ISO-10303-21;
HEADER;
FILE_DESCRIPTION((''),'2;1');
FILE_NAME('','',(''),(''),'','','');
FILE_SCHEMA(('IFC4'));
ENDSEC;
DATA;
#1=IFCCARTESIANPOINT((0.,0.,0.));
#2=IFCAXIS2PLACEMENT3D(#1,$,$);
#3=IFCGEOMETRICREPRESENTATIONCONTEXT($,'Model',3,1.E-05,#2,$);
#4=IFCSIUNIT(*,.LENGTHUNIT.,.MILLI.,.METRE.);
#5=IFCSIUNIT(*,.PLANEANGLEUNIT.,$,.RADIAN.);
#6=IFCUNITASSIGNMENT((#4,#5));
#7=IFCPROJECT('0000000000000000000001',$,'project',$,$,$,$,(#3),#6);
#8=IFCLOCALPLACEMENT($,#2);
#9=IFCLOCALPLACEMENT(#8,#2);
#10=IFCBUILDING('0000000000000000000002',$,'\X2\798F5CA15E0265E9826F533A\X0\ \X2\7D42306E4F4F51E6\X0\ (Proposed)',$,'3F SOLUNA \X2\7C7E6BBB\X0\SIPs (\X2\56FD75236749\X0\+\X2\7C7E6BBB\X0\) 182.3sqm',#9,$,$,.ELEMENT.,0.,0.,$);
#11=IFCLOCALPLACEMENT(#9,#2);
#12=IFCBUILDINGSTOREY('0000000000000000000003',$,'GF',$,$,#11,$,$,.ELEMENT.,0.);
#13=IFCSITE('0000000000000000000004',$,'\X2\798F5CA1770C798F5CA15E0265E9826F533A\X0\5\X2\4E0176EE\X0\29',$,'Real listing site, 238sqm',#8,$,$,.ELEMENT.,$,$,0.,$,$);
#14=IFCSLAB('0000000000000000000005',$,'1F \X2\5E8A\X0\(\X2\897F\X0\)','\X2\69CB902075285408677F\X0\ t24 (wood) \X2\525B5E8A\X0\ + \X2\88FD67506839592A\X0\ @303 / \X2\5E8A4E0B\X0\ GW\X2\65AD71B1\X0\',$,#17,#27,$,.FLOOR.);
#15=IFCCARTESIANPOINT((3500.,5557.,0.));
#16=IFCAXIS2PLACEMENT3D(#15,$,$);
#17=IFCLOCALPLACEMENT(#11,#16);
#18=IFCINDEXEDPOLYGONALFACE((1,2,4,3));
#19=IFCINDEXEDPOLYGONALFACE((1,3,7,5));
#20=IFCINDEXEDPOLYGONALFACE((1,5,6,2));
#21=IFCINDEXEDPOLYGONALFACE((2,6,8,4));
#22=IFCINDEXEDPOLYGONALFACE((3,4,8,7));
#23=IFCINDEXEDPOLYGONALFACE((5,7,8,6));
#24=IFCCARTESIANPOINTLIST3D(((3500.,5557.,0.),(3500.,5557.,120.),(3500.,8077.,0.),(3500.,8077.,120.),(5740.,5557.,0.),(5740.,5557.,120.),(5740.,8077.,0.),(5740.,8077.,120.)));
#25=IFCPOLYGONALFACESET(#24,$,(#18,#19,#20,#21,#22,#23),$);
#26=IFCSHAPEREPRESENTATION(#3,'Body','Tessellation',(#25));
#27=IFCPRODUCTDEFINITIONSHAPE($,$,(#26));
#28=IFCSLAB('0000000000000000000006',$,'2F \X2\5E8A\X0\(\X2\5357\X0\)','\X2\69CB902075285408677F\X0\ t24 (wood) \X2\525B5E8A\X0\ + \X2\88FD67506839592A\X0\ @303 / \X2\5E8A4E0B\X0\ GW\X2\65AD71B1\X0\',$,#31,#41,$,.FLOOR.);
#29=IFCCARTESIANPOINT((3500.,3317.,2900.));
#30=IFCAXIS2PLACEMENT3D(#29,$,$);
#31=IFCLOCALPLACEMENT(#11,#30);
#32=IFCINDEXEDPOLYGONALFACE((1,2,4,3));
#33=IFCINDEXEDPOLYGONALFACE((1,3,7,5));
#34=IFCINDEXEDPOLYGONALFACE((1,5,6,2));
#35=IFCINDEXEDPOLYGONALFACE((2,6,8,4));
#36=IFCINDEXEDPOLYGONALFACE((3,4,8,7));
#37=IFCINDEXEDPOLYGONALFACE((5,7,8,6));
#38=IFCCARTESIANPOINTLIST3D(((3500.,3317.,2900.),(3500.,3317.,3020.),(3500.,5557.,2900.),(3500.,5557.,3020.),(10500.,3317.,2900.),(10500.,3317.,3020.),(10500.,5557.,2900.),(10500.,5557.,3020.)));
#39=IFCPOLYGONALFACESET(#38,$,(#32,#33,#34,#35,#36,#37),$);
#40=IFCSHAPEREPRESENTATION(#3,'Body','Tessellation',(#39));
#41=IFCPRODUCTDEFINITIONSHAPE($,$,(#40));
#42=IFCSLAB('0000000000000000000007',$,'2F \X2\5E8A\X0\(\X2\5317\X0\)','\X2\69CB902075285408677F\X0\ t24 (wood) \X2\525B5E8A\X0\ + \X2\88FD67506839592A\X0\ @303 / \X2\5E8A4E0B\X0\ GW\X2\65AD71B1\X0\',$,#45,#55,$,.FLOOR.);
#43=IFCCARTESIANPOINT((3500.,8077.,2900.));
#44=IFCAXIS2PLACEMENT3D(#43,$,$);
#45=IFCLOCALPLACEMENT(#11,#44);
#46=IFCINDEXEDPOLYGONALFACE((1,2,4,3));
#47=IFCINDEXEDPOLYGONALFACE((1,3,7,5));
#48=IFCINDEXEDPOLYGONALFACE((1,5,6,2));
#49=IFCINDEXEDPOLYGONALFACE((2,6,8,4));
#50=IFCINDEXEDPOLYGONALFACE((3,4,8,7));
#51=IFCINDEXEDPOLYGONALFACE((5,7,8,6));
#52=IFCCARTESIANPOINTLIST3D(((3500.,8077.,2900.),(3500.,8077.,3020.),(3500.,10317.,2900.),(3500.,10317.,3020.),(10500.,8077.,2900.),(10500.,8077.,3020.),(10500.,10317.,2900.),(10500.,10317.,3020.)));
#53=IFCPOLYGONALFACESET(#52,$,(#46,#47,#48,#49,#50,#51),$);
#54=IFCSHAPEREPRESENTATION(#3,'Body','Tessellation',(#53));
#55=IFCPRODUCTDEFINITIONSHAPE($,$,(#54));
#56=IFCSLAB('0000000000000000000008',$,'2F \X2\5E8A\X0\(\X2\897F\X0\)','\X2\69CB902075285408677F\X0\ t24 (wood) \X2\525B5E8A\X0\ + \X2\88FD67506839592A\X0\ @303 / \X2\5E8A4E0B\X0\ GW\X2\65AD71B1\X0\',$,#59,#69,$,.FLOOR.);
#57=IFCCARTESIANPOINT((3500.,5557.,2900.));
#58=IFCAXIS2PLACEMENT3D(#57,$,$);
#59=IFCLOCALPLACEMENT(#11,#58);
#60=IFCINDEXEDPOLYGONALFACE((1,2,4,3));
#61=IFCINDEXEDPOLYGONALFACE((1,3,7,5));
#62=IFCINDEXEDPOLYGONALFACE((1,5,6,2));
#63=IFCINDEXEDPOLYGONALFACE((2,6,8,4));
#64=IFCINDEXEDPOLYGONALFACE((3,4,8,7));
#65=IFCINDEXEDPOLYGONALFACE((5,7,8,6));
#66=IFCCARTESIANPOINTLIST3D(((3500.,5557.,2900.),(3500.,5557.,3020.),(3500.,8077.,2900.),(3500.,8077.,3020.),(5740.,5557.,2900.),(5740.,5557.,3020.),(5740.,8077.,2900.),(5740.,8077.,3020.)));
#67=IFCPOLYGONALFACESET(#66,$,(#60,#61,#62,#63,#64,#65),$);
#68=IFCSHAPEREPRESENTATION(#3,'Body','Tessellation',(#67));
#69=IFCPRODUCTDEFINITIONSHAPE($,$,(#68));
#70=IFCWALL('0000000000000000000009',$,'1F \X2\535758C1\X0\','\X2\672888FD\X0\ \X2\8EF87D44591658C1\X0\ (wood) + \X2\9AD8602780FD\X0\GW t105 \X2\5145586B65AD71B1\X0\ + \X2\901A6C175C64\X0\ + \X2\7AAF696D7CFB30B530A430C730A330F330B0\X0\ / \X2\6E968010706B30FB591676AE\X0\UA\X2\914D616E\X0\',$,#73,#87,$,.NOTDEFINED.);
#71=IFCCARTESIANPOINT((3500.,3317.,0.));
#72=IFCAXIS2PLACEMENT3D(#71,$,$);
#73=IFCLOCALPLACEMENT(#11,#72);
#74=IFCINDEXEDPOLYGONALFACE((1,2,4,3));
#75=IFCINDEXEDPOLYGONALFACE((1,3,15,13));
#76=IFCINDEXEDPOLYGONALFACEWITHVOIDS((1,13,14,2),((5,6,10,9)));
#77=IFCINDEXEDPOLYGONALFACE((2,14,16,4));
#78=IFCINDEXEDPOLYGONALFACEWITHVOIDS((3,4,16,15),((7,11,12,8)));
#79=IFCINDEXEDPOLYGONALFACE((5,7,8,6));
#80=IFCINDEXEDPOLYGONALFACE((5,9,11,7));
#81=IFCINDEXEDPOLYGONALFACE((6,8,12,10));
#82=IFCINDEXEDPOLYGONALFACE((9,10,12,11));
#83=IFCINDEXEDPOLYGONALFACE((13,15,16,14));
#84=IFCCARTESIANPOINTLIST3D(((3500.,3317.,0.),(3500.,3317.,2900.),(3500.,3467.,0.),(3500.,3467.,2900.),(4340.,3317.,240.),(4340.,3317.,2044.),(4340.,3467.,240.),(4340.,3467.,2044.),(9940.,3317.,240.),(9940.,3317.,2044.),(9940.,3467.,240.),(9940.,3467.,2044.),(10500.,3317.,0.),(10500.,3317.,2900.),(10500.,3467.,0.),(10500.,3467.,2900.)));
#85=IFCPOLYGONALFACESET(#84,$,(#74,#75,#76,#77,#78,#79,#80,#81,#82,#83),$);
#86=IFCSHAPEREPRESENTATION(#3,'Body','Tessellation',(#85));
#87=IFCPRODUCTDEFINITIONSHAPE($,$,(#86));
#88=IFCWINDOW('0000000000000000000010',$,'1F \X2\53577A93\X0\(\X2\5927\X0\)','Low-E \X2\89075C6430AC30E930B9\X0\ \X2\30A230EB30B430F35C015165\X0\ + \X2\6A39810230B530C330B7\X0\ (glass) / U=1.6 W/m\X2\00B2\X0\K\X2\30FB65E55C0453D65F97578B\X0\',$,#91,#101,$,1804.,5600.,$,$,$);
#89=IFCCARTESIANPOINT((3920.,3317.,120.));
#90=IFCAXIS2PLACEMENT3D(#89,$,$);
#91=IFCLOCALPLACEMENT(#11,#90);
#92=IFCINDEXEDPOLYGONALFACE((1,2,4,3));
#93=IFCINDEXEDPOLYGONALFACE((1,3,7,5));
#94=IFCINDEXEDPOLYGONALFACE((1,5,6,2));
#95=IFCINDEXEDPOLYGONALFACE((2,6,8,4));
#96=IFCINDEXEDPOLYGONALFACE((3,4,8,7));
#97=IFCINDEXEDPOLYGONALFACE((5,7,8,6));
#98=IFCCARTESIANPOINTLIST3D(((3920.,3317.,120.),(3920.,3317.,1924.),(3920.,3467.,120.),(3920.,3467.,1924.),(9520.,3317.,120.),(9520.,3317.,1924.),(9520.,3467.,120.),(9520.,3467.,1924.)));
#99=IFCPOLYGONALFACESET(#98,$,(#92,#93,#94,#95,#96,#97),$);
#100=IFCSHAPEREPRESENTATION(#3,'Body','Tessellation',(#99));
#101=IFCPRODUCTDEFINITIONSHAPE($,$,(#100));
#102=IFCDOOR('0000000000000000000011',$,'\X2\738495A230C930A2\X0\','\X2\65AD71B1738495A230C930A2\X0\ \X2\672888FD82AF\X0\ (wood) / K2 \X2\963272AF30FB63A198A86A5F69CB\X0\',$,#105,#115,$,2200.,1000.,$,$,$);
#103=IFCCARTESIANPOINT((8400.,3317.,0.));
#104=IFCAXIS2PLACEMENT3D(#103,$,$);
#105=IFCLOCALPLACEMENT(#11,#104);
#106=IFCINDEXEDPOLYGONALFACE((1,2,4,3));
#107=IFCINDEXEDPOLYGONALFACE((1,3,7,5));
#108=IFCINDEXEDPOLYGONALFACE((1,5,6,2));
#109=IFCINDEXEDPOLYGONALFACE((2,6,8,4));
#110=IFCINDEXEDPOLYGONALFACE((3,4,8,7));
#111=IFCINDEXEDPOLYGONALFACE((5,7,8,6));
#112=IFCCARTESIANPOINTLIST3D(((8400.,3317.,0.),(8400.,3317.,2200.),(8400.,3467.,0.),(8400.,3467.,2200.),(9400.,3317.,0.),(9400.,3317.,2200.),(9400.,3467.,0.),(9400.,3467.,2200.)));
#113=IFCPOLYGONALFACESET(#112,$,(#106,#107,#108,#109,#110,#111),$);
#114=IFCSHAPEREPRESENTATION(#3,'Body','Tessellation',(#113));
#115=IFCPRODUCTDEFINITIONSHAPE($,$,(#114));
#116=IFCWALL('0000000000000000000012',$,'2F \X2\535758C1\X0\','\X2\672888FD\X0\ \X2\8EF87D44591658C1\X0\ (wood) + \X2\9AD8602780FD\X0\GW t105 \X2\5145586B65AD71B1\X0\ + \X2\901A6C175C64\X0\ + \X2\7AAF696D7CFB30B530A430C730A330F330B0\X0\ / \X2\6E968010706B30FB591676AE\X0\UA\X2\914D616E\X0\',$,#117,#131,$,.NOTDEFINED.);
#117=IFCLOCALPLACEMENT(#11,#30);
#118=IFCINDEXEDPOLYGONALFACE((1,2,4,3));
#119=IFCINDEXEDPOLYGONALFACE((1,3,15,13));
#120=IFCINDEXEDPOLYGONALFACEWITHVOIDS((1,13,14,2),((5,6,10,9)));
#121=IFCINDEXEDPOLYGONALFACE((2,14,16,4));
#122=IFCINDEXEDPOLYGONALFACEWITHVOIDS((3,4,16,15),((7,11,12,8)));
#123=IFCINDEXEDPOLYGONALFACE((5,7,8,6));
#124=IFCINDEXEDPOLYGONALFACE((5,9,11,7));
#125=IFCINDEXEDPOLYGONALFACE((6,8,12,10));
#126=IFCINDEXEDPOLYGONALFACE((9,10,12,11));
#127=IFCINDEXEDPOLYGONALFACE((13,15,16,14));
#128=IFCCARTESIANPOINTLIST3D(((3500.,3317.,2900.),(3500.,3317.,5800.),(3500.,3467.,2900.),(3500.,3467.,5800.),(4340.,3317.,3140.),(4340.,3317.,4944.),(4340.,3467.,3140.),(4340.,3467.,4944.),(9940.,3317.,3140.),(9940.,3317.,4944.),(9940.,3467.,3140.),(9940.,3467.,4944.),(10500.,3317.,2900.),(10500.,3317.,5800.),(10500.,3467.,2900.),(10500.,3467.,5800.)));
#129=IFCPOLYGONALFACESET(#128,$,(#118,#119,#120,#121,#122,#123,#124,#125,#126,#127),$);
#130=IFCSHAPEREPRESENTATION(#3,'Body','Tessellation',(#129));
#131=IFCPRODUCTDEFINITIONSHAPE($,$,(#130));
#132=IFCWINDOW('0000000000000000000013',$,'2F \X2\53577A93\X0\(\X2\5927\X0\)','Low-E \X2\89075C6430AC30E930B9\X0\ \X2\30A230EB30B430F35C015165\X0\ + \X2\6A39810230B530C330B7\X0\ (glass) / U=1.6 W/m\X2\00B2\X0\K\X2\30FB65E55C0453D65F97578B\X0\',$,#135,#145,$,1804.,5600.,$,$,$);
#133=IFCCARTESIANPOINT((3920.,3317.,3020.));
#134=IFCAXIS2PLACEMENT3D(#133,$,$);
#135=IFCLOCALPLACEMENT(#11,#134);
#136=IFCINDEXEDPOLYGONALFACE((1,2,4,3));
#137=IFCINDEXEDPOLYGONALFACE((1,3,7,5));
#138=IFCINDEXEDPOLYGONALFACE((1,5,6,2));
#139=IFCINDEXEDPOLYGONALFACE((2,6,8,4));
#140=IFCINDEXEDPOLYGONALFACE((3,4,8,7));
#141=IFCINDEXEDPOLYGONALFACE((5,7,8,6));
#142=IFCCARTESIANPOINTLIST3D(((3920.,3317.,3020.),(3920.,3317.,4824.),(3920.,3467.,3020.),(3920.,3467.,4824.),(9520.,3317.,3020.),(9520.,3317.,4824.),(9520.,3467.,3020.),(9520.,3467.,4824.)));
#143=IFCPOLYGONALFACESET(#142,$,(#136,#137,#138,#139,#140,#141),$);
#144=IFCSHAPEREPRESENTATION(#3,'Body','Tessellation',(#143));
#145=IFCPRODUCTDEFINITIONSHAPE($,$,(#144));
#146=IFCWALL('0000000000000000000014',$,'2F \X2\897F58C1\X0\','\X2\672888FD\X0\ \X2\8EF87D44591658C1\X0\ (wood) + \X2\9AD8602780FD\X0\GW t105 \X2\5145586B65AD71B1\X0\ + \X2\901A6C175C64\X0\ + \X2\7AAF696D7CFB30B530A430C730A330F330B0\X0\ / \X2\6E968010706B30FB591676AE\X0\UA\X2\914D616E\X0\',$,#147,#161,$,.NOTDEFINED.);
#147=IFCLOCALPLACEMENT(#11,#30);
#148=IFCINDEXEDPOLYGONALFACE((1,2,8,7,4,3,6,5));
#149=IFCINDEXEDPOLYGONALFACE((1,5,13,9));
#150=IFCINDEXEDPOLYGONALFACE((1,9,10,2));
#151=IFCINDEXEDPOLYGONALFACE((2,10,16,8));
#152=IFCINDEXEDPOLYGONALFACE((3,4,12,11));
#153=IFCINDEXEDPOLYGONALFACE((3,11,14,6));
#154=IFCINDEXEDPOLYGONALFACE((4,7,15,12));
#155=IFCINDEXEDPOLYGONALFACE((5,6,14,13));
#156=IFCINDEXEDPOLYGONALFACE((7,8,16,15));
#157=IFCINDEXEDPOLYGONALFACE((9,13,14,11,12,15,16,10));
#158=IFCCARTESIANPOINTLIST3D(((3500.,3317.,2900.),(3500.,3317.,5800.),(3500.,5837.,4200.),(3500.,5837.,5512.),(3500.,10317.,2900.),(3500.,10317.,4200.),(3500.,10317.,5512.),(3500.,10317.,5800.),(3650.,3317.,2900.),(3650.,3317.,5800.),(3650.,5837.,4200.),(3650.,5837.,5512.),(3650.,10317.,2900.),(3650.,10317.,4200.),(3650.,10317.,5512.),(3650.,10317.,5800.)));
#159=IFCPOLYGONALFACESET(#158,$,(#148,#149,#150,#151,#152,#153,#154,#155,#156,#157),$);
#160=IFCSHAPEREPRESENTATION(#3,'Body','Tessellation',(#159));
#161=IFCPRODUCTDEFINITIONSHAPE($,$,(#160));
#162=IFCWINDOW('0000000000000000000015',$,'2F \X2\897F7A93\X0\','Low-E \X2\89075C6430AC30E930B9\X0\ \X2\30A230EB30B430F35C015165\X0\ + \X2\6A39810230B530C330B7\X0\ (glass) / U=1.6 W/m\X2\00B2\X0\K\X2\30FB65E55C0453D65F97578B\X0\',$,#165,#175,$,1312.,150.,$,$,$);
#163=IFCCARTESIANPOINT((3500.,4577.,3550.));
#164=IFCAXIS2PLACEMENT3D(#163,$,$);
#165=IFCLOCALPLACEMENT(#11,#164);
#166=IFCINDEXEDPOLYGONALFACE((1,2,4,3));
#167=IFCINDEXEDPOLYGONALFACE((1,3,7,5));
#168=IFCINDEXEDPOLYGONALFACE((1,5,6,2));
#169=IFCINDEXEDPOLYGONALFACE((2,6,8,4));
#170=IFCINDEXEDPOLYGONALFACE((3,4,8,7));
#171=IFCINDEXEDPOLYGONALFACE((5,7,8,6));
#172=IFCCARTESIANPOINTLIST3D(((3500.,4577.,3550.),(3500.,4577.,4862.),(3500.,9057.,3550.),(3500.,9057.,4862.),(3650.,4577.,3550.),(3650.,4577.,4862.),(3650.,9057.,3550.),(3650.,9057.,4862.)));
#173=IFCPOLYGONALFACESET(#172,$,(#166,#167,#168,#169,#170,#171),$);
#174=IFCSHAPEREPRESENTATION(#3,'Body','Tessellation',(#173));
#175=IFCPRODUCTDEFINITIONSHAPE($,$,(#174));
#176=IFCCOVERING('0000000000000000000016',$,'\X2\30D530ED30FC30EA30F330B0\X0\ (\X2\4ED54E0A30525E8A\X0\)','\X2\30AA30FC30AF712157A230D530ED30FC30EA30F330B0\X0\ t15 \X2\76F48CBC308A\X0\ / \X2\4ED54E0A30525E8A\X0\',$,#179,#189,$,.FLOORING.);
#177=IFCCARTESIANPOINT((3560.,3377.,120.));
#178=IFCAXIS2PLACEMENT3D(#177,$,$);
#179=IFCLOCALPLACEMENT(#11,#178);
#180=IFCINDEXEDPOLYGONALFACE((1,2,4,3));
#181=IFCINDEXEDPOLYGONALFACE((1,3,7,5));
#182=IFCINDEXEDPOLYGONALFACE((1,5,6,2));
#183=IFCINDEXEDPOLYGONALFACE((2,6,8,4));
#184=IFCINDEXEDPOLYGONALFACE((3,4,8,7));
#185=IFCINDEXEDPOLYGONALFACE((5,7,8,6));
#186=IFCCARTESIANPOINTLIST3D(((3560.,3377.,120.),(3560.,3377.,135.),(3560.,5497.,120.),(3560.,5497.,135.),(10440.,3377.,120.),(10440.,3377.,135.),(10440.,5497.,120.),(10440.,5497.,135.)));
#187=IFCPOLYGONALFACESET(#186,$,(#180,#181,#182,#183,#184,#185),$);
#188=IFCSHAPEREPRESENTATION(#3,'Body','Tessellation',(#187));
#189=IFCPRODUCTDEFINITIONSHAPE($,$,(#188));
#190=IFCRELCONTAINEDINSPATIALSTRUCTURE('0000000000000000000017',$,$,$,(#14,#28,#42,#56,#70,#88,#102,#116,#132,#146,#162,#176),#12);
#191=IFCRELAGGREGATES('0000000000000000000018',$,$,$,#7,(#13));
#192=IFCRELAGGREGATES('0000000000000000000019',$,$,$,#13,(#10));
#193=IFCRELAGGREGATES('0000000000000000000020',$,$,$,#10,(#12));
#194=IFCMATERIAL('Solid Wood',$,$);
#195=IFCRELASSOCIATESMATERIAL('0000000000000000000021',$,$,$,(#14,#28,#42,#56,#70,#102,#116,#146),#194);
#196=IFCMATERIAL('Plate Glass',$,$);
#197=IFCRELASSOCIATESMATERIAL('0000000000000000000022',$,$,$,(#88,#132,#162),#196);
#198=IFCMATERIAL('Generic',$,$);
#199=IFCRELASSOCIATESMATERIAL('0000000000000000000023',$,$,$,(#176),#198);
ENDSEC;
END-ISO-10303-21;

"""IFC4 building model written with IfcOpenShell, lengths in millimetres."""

from ifc_helpers import new_model, si_unit, frame, frame_2d, origin, place, context, project, spatial, rectangle, extrude, material, element, fill, save


model = new_model("IFC4")

# Units and contexts
model_context = context("Model", 3, precision=1e-05, world=origin())
ifc_project = project(units=[si_unit("LENGTHUNIT", "METRE", prefix="MILLI"), si_unit("PLANEANGLEUNIT", "RADIAN")], contexts=[model_context])

# Site, building, storey
site_placement = place(None, origin())
site = spatial("IfcSite", under=ifc_project, at=site_placement, Name="福岡県福岡市早良区5丁目29", ObjectType="Real listing site, 238sqm", CompositionType="ELEMENT", RefElevation=0.0)
building_placement = place(site_placement, origin())
building = spatial("IfcBuilding", under=site, at=building_placement, Name="福岡市早良区 終の住処 (Proposed)", ObjectType="3F SOLUNA 籾殻SIPs (国産杉+籾殻) 182.3sqm", CompositionType="ELEMENT", ElevationOfRefHeight=0.0, ElevationOfTerrain=0.0)
storey_placement = place(building_placement, origin())
storey = spatial("IfcBuildingStorey", under=building, at=storey_placement, Name="GF", CompositionType="ELEMENT", Elevation=0.0)

# Slabs
ifc_material_1 = material(Name="Solid Wood")
slab_1_placement = place(storey_placement, frame((3500.0, 5557.0, 0.0)))
element("IfcSlab", 1, at=slab_1_placement, inside=storey, material=ifc_material_1, Name="1F 床(西)", Description="構造用合板 t24 (wood) 剛床 + 製材根太 @303 / 床下 GW断熱", PredefinedType="FLOOR", context=model_context, shape_type="SweptSolid", body=[
    extrude(rectangle(XDim=2240.0, YDim=2520.0, at=frame_2d((1120.0, 1260.0))), frame((3500.0, 5557.0, 0.0)), (0.0, 0.0, 1.0), 120.0),
])
slab_2_placement = place(storey_placement, frame((3500.0, 3317.0, 2900.0)))
element("IfcSlab", 2, at=slab_2_placement, inside=storey, material=ifc_material_1, Name="2F 床(南)", Description="構造用合板 t24 (wood) 剛床 + 製材根太 @303 / 床下 GW断熱", PredefinedType="FLOOR", context=model_context, shape_type="SweptSolid", body=[
    extrude(rectangle(XDim=7000.0, YDim=2240.0, at=frame_2d((3500.0, 1120.0))), frame((3500.0, 3317.0, 2900.0)), (0.0, 0.0, 1.0), 120.0),
])
slab_3_placement = place(storey_placement, frame((3500.0, 8077.0, 2900.0)))
element("IfcSlab", 3, at=slab_3_placement, inside=storey, material=ifc_material_1, Name="2F 床(北)", Description="構造用合板 t24 (wood) 剛床 + 製材根太 @303 / 床下 GW断熱", PredefinedType="FLOOR", context=model_context, shape_type="SweptSolid", body=[
    extrude(rectangle(XDim=7000.0, YDim=2240.0, at=frame_2d((3500.0, 1120.0))), frame((3500.0, 8077.0, 2900.0)), (0.0, 0.0, 1.0), 120.0),
])
slab_4_placement = place(storey_placement, frame((3500.0, 5557.0, 2900.0)))
element("IfcSlab", 4, at=slab_4_placement, inside=storey, material=ifc_material_1, Name="2F 床(西)", Description="構造用合板 t24 (wood) 剛床 + 製材根太 @303 / 床下 GW断熱", PredefinedType="FLOOR", context=model_context, shape_type="SweptSolid", body=[
    extrude(rectangle(XDim=2240.0, YDim=2520.0, at=frame_2d((1120.0, 1260.0))), frame((3500.0, 5557.0, 2900.0)), (0.0, 0.0, 1.0), 120.0),
])

# Wall, openings, window, door
wall_1_placement = place(storey_placement, frame((3500.0, 3317.0, 0.0)))
wall_1 = element("IfcWall", 5, at=wall_1_placement, inside=storey, material=ifc_material_1, Name="1F 南壁", Description="木製 軸組外壁 (wood) + 高性能GW t105 充填断熱 + 通気層 + 窯業系サイディング / 準耐火・外皮UA配慮", PredefinedType="NOTDEFINED", context=model_context, shape_type="SweptSolid", body=[
    extrude(rectangle(XDim=7000.0, YDim=150.0, at=frame_2d((3500.0, 75.0))), frame((3500.0, 3317.0, 0.0)), (0.0, 0.0, 1.0), 2900.0),
])
opening_1_placement = place(storey_placement, frame((3920.0, 3317.0, 120.0)))
opening_1 = element("IfcOpeningElement", 6, at=opening_1_placement, cuts=wall_1, PredefinedType="NOTDEFINED", context=model_context, shape_type="SweptSolid", body=[
    extrude(rectangle(XDim=5600.0, YDim=150.0, at=frame_2d((2800.0, 75.0))), frame((3920.0, 3317.0, 120.0)), (0.0, 0.0, 1.0), 1804.0),
])
opening_2_placement = place(storey_placement, frame((8400.0, 3317.0, 0.0)))
opening_2 = element("IfcOpeningElement", 7, at=opening_2_placement, cuts=wall_1, PredefinedType="NOTDEFINED", context=model_context, shape_type="SweptSolid", body=[
    extrude(rectangle(XDim=1000.0, YDim=150.0, at=frame_2d((500.0, 75.0))), frame((8400.0, 3317.0, 0.0)), (0.0, 0.0, 1.0), 2200.0),
])
ifc_material_2 = material(Name="Plate Glass")
window_1_placement = place(storey_placement, frame((3920.0, 3317.0, 120.0)))
window_1 = element("IfcWindow", 8, at=window_1_placement, inside=storey, material=ifc_material_2, Name="1F 南窓(大)", Description="Low-E 複層ガラス アルゴン封入 + 樹脂サッシ (glass) / U=1.6 W/m²K・日射取得型", OverallHeight=1804.0, OverallWidth=5600.0, context=model_context, shape_type="SweptSolid", body=[
    extrude(rectangle(XDim=5600.0, YDim=150.0, at=frame_2d((2800.0, 75.0))), frame((3920.0, 3317.0, 120.0)), (0.0, 0.0, 1.0), 1804.0),
])
fill(opening_1, window_1)
door_placement = place(storey_placement, frame((8400.0, 3317.0, 0.0)))
door = element("IfcDoor", 9, at=door_placement, inside=storey, material=ifc_material_1, Name="玄関ドア", Description="断熱玄関ドア 木製芯 (wood) / K2 防犯・採風機構", OverallHeight=2200.0, OverallWidth=1000.0, context=model_context, shape_type="SweptSolid", body=[
    extrude(rectangle(XDim=1000.0, YDim=150.0, at=frame_2d((500.0, 75.0))), frame((8400.0, 3317.0, 0.0)), (0.0, 0.0, 1.0), 2200.0),
])
fill(opening_2, door)

# Wall, opening, window
wall_2_placement = place(storey_placement, frame((3500.0, 3317.0, 2900.0)))
wall_2 = element("IfcWall", 10, at=wall_2_placement, inside=storey, material=ifc_material_1, Name="2F 南壁", Description="木製 軸組外壁 (wood) + 高性能GW t105 充填断熱 + 通気層 + 窯業系サイディング / 準耐火・外皮UA配慮", PredefinedType="NOTDEFINED", context=model_context, shape_type="SweptSolid", body=[
    extrude(rectangle(XDim=7000.0, YDim=150.0, at=frame_2d((3500.0, 75.0))), frame((3500.0, 3317.0, 2900.0)), (0.0, 0.0, 1.0), 2900.0),
])
opening_3_placement = place(storey_placement, frame((3920.0, 3317.0, 3020.0)))
opening_3 = element("IfcOpeningElement", 11, at=opening_3_placement, cuts=wall_2, PredefinedType="NOTDEFINED", context=model_context, shape_type="SweptSolid", body=[
    extrude(rectangle(XDim=5600.0, YDim=150.0, at=frame_2d((2800.0, 75.0))), frame((3920.0, 3317.0, 3020.0)), (0.0, 0.0, 1.0), 1804.0),
])
window_2_placement = place(storey_placement, frame((3920.0, 3317.0, 3020.0)))
window_2 = element("IfcWindow", 12, at=window_2_placement, inside=storey, material=ifc_material_2, Name="2F 南窓(大)", Description="Low-E 複層ガラス アルゴン封入 + 樹脂サッシ (glass) / U=1.6 W/m²K・日射取得型", OverallHeight=1804.0, OverallWidth=5600.0, context=model_context, shape_type="SweptSolid", body=[
    extrude(rectangle(XDim=5600.0, YDim=150.0, at=frame_2d((2800.0, 75.0))), frame((3920.0, 3317.0, 3020.0)), (0.0, 0.0, 1.0), 1804.0),
])
fill(opening_3, window_2)

# Wall, opening, window
wall_3_placement = place(storey_placement, frame((3500.0, 3317.0, 2900.0)))
wall_3 = element("IfcWall", 13, at=wall_3_placement, inside=storey, material=ifc_material_1, Name="2F 西壁", Description="木製 軸組外壁 (wood) + 高性能GW t105 充填断熱 + 通気層 + 窯業系サイディング / 準耐火・外皮UA配慮", PredefinedType="NOTDEFINED", context=model_context, shape_type="SweptSolid", body=[
    extrude(rectangle(XDim=150.0, YDim=7000.0, at=frame_2d((75.0, 3500.0))), frame((3500.0, 3317.0, 2900.0)), (0.0, 0.0, 1.0), 2900.0),
])
opening_4_placement = place(storey_placement, frame((3500.0, 4577.0, 3550.0)))
opening_4 = element("IfcOpeningElement", 14, at=opening_4_placement, cuts=wall_3, PredefinedType="NOTDEFINED", context=model_context, shape_type="SweptSolid", body=[
    extrude(rectangle(XDim=150.0, YDim=4480.0, at=frame_2d((75.0, 2240.0))), frame((3500.0, 4577.0, 3550.0)), (0.0, 0.0, 1.0), 1312.0),
])
window_3_placement = place(storey_placement, frame((3500.0, 4577.0, 3550.0)))
window_3 = element("IfcWindow", 15, at=window_3_placement, inside=storey, material=ifc_material_2, Name="2F 西窓", Description="Low-E 複層ガラス アルゴン封入 + 樹脂サッシ (glass) / U=1.6 W/m²K・日射取得型", OverallHeight=1312.0, OverallWidth=150.0, context=model_context, shape_type="SweptSolid", body=[
    extrude(rectangle(XDim=150.0, YDim=4480.0, at=frame_2d((75.0, 2240.0))), frame((3500.0, 4577.0, 3550.0)), (0.0, 0.0, 1.0), 1312.0),
])
fill(opening_4, window_3)

# Covering
ifc_material_3 = material(Name="Generic")
covering_1_placement = place(storey_placement, frame((3560.0, 3377.0, 120.0)))
element("IfcCovering", 16, at=covering_1_placement, inside=storey, material=ifc_material_3, Name="フローリング (仕上げ床)", Description="オーク無垢フローリング t15 直貼り / 仕上げ床", PredefinedType="FLOORING", context=model_context, shape_type="SweptSolid", body=[
    extrude(rectangle(XDim=6880.0, YDim=2120.0, at=frame_2d((3440.0, 1060.0))), frame((3560.0, 3377.0, 120.0)), (0.0, 0.0, 1.0), 15.0),
])

save(model, "model.ifc")
